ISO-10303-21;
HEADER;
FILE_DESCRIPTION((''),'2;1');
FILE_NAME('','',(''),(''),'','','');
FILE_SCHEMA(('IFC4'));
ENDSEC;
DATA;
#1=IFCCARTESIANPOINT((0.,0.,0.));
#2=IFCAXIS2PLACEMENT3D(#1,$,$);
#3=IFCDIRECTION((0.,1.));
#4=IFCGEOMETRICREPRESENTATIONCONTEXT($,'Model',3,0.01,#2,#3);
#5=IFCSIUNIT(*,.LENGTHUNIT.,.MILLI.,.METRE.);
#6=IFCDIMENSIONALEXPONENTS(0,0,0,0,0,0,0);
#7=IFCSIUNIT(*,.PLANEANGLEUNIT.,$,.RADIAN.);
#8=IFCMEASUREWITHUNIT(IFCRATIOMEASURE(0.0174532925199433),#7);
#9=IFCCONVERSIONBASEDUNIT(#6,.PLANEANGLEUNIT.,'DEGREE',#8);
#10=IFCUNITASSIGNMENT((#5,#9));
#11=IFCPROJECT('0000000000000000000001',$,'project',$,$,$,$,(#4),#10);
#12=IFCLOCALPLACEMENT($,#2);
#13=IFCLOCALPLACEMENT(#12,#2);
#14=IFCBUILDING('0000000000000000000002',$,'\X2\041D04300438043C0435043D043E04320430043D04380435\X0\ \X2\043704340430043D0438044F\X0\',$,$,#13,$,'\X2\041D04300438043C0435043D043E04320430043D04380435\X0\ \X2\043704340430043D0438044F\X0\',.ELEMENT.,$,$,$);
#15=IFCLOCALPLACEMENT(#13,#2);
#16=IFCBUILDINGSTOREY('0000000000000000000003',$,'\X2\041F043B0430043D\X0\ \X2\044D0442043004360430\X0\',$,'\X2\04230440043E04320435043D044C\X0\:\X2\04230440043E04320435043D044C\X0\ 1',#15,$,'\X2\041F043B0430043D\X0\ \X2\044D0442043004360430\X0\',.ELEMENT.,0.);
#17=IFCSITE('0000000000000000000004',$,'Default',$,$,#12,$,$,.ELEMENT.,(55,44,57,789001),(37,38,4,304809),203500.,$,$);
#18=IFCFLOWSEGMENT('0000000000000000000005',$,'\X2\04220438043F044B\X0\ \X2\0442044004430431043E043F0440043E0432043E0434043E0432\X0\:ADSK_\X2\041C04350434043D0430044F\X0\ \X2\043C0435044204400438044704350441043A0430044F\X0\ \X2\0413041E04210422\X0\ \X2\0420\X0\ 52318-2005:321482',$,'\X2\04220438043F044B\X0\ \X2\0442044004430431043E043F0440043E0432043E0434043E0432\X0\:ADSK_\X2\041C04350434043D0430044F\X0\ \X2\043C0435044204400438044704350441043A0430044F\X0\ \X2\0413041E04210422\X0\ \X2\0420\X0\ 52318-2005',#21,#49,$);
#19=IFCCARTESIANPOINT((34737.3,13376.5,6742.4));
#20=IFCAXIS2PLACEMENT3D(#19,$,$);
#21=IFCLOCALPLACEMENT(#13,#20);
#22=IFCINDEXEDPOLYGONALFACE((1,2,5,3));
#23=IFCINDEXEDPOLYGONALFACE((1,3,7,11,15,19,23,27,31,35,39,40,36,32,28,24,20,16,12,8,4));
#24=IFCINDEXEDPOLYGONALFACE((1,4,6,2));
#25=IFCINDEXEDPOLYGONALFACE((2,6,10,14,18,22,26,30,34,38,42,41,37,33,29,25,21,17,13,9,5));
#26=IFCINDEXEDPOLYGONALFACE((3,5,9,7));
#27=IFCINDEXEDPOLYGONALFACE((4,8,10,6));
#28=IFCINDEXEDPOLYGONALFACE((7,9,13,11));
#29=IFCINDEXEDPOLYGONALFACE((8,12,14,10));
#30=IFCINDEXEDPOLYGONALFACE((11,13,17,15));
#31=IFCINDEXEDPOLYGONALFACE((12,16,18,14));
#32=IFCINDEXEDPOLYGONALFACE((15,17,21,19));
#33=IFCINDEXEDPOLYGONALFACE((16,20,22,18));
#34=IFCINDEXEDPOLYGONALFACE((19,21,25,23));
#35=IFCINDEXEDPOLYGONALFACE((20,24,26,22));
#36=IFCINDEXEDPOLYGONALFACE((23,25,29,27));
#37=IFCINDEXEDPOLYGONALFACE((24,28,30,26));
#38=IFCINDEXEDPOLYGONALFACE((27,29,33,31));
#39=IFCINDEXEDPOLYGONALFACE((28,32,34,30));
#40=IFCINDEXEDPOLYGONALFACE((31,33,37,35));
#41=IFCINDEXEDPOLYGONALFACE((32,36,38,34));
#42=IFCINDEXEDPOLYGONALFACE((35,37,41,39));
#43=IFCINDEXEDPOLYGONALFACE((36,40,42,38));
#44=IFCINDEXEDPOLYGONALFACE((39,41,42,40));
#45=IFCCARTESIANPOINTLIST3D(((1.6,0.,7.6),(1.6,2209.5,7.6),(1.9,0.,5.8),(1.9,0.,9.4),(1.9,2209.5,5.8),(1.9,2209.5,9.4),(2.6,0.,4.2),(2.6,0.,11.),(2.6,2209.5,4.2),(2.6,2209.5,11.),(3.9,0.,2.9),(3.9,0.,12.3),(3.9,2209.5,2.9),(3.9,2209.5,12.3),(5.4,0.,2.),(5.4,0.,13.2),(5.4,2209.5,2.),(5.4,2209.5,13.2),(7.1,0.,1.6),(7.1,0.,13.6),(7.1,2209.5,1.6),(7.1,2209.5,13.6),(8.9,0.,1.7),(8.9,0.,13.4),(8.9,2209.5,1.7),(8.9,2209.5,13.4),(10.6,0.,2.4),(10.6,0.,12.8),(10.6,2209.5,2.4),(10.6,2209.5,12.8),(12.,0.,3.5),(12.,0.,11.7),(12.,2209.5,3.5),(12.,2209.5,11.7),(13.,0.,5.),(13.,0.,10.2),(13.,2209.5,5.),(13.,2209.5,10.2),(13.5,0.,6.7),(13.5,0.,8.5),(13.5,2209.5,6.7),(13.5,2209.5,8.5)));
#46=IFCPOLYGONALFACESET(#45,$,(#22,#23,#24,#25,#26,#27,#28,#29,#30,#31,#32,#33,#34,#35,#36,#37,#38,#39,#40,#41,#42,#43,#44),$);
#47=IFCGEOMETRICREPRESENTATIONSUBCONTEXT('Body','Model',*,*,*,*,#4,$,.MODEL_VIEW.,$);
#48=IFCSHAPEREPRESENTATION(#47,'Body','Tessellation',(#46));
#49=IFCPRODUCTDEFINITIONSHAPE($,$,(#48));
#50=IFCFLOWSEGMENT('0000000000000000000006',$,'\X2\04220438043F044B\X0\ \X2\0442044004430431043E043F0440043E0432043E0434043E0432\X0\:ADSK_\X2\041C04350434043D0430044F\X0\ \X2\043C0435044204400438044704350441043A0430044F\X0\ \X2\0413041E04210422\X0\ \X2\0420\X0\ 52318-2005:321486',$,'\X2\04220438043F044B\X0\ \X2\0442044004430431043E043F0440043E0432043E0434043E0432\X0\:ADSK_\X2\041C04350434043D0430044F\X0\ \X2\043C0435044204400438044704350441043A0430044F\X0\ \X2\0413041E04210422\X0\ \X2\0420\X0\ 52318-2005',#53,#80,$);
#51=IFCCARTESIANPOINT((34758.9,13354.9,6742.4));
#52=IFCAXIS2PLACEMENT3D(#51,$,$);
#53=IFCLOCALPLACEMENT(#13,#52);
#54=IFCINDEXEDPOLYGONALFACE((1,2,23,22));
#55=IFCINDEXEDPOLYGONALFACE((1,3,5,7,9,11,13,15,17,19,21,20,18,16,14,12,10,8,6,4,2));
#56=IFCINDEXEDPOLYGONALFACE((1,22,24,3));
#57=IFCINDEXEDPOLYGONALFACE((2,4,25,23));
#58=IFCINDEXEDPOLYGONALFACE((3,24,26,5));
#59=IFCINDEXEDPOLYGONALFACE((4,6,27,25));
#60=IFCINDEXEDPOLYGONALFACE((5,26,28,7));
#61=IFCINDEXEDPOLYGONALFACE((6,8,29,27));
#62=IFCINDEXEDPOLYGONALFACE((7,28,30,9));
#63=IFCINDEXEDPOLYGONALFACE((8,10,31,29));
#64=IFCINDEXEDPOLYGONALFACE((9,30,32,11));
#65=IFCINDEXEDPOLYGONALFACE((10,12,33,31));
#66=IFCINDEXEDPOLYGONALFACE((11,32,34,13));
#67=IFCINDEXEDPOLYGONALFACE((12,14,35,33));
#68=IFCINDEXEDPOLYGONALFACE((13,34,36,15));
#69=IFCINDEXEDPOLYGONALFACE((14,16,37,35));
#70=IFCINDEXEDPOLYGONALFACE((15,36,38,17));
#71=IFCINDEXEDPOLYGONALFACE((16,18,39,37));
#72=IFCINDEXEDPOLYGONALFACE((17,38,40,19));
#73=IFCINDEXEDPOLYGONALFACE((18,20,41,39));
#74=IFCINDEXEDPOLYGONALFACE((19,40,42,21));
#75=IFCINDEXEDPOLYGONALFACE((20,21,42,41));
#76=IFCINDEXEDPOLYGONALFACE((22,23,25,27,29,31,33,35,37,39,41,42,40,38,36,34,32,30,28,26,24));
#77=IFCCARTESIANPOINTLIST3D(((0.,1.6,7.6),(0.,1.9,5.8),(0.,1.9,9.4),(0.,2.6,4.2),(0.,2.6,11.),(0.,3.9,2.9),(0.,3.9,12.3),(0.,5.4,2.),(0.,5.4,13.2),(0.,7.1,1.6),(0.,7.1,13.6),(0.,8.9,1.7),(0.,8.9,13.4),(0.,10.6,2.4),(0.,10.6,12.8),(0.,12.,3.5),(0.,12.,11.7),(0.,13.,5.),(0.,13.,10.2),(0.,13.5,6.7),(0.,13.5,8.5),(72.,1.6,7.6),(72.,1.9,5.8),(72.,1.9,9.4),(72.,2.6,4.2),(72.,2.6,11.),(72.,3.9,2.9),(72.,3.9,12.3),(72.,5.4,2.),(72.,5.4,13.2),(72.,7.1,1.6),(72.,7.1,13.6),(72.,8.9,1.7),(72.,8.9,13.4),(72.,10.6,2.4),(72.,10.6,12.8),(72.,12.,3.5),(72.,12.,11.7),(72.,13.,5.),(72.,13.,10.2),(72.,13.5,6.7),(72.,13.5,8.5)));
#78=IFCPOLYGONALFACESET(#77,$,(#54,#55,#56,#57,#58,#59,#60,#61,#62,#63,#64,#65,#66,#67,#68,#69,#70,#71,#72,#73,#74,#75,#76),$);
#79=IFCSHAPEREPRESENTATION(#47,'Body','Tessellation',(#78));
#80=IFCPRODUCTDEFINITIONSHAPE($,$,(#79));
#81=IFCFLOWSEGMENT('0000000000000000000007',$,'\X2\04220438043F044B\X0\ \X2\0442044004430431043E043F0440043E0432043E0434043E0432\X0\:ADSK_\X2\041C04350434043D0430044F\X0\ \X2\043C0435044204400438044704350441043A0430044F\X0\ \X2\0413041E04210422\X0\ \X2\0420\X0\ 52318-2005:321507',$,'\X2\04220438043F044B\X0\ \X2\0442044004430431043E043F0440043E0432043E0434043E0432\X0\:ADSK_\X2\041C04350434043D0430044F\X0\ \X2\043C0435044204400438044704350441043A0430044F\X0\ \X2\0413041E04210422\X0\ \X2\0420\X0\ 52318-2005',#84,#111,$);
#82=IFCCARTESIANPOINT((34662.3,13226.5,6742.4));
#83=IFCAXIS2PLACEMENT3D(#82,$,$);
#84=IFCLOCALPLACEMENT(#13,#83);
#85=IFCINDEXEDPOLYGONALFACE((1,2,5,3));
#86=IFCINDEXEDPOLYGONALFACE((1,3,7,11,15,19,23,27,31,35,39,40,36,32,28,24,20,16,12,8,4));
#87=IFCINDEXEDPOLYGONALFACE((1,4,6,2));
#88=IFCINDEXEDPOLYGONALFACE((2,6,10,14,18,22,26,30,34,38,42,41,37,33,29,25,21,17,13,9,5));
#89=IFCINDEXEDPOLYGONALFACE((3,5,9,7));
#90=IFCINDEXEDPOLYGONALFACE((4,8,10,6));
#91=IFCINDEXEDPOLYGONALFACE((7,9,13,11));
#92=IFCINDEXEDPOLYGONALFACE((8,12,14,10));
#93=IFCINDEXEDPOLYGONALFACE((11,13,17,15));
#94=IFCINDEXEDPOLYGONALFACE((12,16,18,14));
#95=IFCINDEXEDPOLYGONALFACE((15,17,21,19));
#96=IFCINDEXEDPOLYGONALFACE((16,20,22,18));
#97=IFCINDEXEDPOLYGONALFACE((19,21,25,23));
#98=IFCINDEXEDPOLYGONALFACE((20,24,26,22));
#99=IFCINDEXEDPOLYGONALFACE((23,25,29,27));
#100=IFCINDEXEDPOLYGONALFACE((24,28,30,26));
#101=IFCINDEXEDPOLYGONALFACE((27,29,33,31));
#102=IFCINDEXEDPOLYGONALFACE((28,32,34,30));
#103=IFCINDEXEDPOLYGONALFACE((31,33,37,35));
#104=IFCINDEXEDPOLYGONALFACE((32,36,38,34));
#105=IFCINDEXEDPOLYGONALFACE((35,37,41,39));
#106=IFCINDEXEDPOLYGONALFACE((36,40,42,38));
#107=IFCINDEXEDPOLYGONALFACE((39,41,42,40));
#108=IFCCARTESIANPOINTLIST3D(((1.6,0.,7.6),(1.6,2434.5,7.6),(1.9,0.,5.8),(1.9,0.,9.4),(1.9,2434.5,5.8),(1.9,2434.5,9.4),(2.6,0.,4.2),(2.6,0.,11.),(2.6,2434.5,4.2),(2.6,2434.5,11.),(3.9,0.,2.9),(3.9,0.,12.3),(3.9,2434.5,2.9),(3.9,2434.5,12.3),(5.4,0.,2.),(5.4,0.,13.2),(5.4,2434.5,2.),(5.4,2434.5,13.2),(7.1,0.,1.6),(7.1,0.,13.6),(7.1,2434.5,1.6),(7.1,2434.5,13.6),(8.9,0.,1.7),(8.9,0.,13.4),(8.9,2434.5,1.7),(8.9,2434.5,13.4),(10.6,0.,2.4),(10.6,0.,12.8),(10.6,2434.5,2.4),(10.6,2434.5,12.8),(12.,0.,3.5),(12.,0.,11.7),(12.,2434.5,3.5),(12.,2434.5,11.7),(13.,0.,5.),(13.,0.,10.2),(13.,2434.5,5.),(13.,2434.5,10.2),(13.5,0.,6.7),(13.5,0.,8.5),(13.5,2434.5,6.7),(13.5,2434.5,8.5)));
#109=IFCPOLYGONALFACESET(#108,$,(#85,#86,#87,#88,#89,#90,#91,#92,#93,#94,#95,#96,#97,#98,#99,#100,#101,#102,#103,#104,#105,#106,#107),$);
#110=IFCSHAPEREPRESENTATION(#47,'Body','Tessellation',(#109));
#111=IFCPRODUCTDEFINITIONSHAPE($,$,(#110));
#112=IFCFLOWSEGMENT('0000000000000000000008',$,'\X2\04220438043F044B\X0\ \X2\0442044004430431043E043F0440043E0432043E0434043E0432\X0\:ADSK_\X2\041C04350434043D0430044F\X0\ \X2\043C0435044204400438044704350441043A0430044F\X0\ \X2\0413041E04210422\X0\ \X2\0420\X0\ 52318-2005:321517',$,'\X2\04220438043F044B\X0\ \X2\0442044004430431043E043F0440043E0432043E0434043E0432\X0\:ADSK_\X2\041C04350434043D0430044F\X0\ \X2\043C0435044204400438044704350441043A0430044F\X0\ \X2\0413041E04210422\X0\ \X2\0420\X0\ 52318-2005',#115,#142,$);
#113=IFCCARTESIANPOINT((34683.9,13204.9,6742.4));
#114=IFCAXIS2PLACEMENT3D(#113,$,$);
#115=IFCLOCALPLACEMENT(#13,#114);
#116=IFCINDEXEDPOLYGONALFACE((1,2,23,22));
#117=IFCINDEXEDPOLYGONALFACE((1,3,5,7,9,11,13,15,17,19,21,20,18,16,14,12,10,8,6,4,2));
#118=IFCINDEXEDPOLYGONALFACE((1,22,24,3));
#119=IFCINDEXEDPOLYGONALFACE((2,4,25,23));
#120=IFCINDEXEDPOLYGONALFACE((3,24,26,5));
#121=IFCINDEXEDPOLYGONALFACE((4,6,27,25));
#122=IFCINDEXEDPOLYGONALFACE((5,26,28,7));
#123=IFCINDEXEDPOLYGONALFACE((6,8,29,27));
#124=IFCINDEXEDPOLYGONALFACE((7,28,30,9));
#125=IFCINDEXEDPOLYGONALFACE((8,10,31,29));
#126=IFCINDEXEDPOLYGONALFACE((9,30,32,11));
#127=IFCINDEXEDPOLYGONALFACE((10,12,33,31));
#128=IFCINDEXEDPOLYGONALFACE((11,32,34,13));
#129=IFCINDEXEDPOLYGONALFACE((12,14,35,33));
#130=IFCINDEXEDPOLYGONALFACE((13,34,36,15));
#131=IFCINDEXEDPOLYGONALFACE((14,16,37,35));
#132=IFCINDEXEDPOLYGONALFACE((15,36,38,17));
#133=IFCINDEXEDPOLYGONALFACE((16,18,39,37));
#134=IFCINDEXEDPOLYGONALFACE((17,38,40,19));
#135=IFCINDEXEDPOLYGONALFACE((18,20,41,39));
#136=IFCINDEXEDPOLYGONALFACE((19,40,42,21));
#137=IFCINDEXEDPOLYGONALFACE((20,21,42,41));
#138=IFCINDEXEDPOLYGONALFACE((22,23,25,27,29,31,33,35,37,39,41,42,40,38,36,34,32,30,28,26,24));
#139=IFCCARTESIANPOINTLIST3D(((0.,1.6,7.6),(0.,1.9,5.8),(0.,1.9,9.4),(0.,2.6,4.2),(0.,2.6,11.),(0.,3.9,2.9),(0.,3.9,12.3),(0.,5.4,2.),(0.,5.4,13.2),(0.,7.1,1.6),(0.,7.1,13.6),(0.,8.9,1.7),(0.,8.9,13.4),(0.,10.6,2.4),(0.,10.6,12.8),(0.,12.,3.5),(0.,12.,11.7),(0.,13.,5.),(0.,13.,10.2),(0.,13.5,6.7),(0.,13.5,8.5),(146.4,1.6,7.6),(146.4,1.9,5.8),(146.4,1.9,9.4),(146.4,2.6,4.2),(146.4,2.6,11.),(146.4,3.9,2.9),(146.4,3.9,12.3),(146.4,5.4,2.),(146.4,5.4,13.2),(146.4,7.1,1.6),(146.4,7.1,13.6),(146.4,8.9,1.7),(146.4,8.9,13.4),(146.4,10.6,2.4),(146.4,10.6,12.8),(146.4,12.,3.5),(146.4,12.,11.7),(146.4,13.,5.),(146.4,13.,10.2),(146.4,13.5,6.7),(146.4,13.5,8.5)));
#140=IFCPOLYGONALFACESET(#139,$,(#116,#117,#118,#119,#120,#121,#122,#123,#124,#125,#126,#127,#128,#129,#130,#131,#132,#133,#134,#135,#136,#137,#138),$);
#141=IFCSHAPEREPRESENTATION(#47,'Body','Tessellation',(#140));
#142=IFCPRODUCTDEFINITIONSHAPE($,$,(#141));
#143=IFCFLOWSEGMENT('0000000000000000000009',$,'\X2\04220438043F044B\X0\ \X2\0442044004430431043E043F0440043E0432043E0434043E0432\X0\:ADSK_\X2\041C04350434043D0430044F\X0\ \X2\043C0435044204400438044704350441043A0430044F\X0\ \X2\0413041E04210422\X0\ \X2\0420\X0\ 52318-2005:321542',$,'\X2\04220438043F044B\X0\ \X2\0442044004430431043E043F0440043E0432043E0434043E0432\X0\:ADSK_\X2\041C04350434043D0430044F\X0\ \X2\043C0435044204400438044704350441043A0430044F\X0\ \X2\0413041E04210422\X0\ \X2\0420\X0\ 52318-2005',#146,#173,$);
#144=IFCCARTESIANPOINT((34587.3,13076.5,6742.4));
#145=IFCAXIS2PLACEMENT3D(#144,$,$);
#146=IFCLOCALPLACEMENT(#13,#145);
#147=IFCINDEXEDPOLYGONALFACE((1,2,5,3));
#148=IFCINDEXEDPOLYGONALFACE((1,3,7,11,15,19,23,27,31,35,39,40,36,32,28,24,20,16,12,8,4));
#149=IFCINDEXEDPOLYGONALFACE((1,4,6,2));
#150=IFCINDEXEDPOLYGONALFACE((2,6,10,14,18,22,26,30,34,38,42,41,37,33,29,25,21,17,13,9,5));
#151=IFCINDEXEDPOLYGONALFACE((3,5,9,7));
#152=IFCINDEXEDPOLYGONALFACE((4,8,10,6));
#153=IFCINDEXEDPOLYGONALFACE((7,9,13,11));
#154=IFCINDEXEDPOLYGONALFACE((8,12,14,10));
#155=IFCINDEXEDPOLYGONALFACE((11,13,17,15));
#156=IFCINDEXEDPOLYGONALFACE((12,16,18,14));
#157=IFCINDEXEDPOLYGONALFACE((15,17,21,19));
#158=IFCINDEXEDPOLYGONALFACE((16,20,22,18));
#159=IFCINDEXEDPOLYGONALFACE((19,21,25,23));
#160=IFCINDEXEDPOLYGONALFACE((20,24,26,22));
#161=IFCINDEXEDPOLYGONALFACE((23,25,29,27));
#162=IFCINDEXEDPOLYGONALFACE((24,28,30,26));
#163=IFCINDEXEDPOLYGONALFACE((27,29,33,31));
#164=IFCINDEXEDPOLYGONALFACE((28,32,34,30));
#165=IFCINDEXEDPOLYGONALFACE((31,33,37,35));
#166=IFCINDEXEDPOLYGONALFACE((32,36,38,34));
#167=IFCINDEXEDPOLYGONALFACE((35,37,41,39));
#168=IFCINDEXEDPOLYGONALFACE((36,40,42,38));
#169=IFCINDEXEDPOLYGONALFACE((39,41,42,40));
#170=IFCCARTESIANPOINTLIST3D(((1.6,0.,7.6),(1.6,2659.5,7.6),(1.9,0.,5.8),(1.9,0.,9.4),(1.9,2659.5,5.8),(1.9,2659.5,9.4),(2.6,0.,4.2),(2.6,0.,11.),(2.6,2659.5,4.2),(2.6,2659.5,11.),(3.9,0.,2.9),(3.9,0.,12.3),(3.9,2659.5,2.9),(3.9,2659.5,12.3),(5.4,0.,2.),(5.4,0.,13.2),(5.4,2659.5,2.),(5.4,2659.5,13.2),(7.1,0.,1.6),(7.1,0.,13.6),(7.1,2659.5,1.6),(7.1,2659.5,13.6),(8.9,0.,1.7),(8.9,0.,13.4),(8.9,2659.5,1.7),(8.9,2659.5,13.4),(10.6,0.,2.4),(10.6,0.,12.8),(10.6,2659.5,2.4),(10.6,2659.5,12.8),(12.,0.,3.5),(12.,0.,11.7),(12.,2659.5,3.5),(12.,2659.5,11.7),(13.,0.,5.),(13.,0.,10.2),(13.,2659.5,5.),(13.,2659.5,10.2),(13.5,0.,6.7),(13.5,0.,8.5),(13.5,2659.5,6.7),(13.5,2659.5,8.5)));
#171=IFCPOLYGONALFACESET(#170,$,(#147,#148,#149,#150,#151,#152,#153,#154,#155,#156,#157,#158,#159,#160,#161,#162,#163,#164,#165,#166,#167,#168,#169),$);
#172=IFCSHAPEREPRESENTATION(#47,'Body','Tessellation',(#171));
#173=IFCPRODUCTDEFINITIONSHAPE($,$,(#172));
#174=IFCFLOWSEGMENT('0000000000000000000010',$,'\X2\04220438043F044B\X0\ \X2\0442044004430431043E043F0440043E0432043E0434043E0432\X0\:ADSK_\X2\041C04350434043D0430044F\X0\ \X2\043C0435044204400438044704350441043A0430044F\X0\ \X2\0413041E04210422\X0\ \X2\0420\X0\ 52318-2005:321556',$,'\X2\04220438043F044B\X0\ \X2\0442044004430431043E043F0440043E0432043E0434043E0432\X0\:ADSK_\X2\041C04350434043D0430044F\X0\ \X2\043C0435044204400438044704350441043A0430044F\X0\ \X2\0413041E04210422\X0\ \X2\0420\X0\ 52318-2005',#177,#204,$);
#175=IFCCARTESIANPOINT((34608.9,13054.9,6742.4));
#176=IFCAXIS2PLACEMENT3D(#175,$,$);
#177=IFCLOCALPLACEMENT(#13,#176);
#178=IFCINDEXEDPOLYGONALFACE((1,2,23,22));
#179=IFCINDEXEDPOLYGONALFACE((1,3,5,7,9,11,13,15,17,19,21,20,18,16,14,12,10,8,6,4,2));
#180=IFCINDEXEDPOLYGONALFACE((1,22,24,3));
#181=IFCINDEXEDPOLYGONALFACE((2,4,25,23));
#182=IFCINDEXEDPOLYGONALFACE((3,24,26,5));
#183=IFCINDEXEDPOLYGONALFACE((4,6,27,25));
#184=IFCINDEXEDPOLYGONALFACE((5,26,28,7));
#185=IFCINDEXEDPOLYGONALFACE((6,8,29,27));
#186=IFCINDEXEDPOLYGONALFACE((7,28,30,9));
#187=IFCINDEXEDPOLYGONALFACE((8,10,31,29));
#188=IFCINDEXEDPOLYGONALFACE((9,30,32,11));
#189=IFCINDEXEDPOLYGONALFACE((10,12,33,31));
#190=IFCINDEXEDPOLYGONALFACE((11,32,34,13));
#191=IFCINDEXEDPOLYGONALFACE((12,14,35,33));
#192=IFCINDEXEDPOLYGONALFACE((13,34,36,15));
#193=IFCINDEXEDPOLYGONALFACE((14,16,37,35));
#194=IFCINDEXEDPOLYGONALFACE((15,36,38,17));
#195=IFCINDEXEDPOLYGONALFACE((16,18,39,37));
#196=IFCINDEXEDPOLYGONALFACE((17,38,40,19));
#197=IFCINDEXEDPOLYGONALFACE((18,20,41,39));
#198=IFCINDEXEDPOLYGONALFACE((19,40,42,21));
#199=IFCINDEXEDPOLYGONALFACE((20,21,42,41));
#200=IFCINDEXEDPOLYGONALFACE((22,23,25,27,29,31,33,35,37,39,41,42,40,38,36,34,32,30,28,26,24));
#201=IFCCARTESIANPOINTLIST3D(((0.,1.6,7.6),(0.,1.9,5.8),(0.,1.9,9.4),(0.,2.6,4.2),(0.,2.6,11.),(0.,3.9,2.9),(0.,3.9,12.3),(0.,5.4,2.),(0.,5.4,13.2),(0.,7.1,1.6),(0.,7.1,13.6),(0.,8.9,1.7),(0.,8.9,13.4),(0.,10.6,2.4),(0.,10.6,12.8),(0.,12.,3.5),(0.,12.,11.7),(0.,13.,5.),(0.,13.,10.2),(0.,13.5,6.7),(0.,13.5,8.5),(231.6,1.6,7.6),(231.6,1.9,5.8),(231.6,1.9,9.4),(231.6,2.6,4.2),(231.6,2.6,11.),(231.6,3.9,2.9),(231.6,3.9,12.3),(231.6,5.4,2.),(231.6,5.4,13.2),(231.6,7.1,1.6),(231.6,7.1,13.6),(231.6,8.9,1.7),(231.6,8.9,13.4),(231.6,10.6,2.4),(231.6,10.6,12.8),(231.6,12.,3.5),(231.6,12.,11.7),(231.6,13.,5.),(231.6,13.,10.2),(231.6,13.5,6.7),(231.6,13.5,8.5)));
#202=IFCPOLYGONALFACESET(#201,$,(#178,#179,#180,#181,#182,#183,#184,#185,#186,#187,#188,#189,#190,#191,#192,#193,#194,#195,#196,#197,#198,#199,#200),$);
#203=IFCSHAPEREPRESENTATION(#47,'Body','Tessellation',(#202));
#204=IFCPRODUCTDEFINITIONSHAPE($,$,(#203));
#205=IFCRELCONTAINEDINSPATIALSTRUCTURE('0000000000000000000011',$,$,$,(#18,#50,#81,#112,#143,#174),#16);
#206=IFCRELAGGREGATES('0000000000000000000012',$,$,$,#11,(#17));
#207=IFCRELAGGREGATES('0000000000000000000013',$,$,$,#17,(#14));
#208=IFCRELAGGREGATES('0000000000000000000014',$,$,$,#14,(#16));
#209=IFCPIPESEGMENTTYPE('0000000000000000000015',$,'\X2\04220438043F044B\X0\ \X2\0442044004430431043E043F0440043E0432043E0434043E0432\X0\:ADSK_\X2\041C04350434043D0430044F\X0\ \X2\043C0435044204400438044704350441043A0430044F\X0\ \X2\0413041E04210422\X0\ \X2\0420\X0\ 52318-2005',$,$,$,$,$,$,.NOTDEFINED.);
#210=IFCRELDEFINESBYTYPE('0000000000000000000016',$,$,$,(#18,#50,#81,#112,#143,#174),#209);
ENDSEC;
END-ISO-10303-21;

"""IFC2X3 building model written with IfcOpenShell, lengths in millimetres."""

from ifc_helpers import new_model, entity, si_unit, converted_unit, direction, frame, frame_2d, origin, origin_2d_with_axis, place, context, subcontext, project, spatial, circle, extrude, type_object, element, save


model = new_model("IFC2X3")

# Units and contexts
model_context = context("Model", 3, precision=0.01, world=origin(), true_north=direction((0.0, 1.0)))
body_context = subcontext(model_context, "Body", "Model", "MODEL_VIEW")
ifc_project = project(units=[si_unit("LENGTHUNIT", "METRE", prefix="MILLI"), converted_unit("PLANEANGLEUNIT", "DEGREE", entity("IfcRatioMeasure", 0.0174532925199433), si_unit("PLANEANGLEUNIT", "RADIAN"), dimensions=[0, 0, 0, 0, 0, 0, 0])], contexts=[model_context])

# Site, building, storey
site_placement = place(None, frame((0.0, 0.0, 0.0)))
site = spatial("IfcSite", under=ifc_project, at=site_placement, Name="Default", CompositionType="ELEMENT", RefLatitude=(55, 44, 57, 789001), RefLongitude=(37, 38, 4, 304809), RefElevation=203500.0)
building_placement = place(site_placement, origin())
building = spatial("IfcBuilding", under=site, at=building_placement, Name="Наименование здания", LongName="Наименование здания", CompositionType="ELEMENT")
storey_placement = place(building_placement, origin())
storey = spatial("IfcBuildingStorey", under=building, at=storey_placement, Name="План этажа", ObjectType="Уровень:Уровень 1", LongName="План этажа", CompositionType="ELEMENT", Elevation=0.0)

# Flow segments
pipe_segment_type = type_object("IfcPipeSegmentType", Name="Типы трубопроводов:ADSK_Медная метрическая ГОСТ Р 52318-2005", PredefinedType="NOTDEFINED")
flow_segment_1_placement = place(building_placement, frame((34737.3, 13376.5, 6742.4)))
element("IfcFlowSegment", 1, at=flow_segment_1_placement, inside=storey, type_object=pipe_segment_type, Name="Типы трубопроводов:ADSK_Медная метрическая ГОСТ Р 52318-2005:321482", ObjectType="Типы трубопроводов:ADSK_Медная метрическая ГОСТ Р 52318-2005", context=body_context, shape_type="SweptSolid", body=[
    extrude(circle(Radius=6.0, at=frame_2d((0.0, 0.0), x_axis=(1.0, 0.0))), frame((7.6, 0.0, 7.6), z_axis=(0.0, 1.0, 0.0), x_axis=(-1.0, 0.0, 0.0)), (0.0, 0.0, 1.0), 2209.5),
])
flow_segment_2_placement = place(building_placement, frame((34758.9, 13354.9, 6742.4)))
element("IfcFlowSegment", 2, at=flow_segment_2_placement, inside=storey, type_object=pipe_segment_type, Name="Типы трубопроводов:ADSK_Медная метрическая ГОСТ Р 52318-2005:321486", ObjectType="Типы трубопроводов:ADSK_Медная метрическая ГОСТ Р 52318-2005", context=body_context, shape_type="SweptSolid", body=[
    extrude(circle(Radius=6.0, at=origin_2d_with_axis()), frame((0.0, 7.6, 7.6), z_axis=(1.0, 0.0, 0.0), x_axis=(0.0, -1.0, 0.0)), (0.0, 0.0, 1.0), 72.0),
])
flow_segment_3_placement = place(building_placement, frame((34662.3, 13226.5, 6742.4)))
element("IfcFlowSegment", 3, at=flow_segment_3_placement, inside=storey, type_object=pipe_segment_type, Name="Типы трубопроводов:ADSK_Медная метрическая ГОСТ Р 52318-2005:321507", ObjectType="Типы трубопроводов:ADSK_Медная метрическая ГОСТ Р 52318-2005", context=body_context, shape_type="SweptSolid", body=[
    extrude(circle(Radius=6.0, at=frame_2d((0.0, 0.0), x_axis=(1.0, 0.0))), frame((7.6, 0.0, 7.6), z_axis=(0.0, 1.0, 0.0), x_axis=(-1.0, 0.0, 0.0)), (0.0, 0.0, 1.0), 2434.5),
])
flow_segment_4_placement = place(building_placement, frame((34683.9, 13204.9, 6742.4)))
element("IfcFlowSegment", 4, at=flow_segment_4_placement, inside=storey, type_object=pipe_segment_type, Name="Типы трубопроводов:ADSK_Медная метрическая ГОСТ Р 52318-2005:321517", ObjectType="Типы трубопроводов:ADSK_Медная метрическая ГОСТ Р 52318-2005", context=body_context, shape_type="SweptSolid", body=[
    extrude(circle(Radius=6.0, at=origin_2d_with_axis()), frame((0.0, 7.6, 7.6), z_axis=(1.0, 0.0, 0.0), x_axis=(0.0, -1.0, 0.0)), (0.0, 0.0, 1.0), 146.4),
])
flow_segment_5_placement = place(building_placement, frame((34587.3, 13076.5, 6742.4)))
element("IfcFlowSegment", 5, at=flow_segment_5_placement, inside=storey, type_object=pipe_segment_type, Name="Типы трубопроводов:ADSK_Медная метрическая ГОСТ Р 52318-2005:321542", ObjectType="Типы трубопроводов:ADSK_Медная метрическая ГОСТ Р 52318-2005", context=body_context, shape_type="SweptSolid", body=[
    extrude(circle(Radius=6.0, at=frame_2d((0.0, 0.0), x_axis=(1.0, 0.0))), frame((7.6, 0.0, 7.6), z_axis=(0.0, 1.0, 0.0), x_axis=(-1.0, 0.0, 0.0)), (0.0, 0.0, 1.0), 2659.5),
])
flow_segment_6_placement = place(building_placement, frame((34608.9, 13054.9, 6742.4)))
element("IfcFlowSegment", 6, at=flow_segment_6_placement, inside=storey, type_object=pipe_segment_type, Name="Типы трубопроводов:ADSK_Медная метрическая ГОСТ Р 52318-2005:321556", ObjectType="Типы трубопроводов:ADSK_Медная метрическая ГОСТ Р 52318-2005", context=body_context, shape_type="SweptSolid", body=[
    extrude(circle(Radius=6.0, at=origin_2d_with_axis()), frame((0.0, 7.6, 7.6), z_axis=(1.0, 0.0, 0.0), x_axis=(0.0, -1.0, 0.0)), (0.0, 0.0, 1.0), 231.6),
])

save(model, "model.ifc")
